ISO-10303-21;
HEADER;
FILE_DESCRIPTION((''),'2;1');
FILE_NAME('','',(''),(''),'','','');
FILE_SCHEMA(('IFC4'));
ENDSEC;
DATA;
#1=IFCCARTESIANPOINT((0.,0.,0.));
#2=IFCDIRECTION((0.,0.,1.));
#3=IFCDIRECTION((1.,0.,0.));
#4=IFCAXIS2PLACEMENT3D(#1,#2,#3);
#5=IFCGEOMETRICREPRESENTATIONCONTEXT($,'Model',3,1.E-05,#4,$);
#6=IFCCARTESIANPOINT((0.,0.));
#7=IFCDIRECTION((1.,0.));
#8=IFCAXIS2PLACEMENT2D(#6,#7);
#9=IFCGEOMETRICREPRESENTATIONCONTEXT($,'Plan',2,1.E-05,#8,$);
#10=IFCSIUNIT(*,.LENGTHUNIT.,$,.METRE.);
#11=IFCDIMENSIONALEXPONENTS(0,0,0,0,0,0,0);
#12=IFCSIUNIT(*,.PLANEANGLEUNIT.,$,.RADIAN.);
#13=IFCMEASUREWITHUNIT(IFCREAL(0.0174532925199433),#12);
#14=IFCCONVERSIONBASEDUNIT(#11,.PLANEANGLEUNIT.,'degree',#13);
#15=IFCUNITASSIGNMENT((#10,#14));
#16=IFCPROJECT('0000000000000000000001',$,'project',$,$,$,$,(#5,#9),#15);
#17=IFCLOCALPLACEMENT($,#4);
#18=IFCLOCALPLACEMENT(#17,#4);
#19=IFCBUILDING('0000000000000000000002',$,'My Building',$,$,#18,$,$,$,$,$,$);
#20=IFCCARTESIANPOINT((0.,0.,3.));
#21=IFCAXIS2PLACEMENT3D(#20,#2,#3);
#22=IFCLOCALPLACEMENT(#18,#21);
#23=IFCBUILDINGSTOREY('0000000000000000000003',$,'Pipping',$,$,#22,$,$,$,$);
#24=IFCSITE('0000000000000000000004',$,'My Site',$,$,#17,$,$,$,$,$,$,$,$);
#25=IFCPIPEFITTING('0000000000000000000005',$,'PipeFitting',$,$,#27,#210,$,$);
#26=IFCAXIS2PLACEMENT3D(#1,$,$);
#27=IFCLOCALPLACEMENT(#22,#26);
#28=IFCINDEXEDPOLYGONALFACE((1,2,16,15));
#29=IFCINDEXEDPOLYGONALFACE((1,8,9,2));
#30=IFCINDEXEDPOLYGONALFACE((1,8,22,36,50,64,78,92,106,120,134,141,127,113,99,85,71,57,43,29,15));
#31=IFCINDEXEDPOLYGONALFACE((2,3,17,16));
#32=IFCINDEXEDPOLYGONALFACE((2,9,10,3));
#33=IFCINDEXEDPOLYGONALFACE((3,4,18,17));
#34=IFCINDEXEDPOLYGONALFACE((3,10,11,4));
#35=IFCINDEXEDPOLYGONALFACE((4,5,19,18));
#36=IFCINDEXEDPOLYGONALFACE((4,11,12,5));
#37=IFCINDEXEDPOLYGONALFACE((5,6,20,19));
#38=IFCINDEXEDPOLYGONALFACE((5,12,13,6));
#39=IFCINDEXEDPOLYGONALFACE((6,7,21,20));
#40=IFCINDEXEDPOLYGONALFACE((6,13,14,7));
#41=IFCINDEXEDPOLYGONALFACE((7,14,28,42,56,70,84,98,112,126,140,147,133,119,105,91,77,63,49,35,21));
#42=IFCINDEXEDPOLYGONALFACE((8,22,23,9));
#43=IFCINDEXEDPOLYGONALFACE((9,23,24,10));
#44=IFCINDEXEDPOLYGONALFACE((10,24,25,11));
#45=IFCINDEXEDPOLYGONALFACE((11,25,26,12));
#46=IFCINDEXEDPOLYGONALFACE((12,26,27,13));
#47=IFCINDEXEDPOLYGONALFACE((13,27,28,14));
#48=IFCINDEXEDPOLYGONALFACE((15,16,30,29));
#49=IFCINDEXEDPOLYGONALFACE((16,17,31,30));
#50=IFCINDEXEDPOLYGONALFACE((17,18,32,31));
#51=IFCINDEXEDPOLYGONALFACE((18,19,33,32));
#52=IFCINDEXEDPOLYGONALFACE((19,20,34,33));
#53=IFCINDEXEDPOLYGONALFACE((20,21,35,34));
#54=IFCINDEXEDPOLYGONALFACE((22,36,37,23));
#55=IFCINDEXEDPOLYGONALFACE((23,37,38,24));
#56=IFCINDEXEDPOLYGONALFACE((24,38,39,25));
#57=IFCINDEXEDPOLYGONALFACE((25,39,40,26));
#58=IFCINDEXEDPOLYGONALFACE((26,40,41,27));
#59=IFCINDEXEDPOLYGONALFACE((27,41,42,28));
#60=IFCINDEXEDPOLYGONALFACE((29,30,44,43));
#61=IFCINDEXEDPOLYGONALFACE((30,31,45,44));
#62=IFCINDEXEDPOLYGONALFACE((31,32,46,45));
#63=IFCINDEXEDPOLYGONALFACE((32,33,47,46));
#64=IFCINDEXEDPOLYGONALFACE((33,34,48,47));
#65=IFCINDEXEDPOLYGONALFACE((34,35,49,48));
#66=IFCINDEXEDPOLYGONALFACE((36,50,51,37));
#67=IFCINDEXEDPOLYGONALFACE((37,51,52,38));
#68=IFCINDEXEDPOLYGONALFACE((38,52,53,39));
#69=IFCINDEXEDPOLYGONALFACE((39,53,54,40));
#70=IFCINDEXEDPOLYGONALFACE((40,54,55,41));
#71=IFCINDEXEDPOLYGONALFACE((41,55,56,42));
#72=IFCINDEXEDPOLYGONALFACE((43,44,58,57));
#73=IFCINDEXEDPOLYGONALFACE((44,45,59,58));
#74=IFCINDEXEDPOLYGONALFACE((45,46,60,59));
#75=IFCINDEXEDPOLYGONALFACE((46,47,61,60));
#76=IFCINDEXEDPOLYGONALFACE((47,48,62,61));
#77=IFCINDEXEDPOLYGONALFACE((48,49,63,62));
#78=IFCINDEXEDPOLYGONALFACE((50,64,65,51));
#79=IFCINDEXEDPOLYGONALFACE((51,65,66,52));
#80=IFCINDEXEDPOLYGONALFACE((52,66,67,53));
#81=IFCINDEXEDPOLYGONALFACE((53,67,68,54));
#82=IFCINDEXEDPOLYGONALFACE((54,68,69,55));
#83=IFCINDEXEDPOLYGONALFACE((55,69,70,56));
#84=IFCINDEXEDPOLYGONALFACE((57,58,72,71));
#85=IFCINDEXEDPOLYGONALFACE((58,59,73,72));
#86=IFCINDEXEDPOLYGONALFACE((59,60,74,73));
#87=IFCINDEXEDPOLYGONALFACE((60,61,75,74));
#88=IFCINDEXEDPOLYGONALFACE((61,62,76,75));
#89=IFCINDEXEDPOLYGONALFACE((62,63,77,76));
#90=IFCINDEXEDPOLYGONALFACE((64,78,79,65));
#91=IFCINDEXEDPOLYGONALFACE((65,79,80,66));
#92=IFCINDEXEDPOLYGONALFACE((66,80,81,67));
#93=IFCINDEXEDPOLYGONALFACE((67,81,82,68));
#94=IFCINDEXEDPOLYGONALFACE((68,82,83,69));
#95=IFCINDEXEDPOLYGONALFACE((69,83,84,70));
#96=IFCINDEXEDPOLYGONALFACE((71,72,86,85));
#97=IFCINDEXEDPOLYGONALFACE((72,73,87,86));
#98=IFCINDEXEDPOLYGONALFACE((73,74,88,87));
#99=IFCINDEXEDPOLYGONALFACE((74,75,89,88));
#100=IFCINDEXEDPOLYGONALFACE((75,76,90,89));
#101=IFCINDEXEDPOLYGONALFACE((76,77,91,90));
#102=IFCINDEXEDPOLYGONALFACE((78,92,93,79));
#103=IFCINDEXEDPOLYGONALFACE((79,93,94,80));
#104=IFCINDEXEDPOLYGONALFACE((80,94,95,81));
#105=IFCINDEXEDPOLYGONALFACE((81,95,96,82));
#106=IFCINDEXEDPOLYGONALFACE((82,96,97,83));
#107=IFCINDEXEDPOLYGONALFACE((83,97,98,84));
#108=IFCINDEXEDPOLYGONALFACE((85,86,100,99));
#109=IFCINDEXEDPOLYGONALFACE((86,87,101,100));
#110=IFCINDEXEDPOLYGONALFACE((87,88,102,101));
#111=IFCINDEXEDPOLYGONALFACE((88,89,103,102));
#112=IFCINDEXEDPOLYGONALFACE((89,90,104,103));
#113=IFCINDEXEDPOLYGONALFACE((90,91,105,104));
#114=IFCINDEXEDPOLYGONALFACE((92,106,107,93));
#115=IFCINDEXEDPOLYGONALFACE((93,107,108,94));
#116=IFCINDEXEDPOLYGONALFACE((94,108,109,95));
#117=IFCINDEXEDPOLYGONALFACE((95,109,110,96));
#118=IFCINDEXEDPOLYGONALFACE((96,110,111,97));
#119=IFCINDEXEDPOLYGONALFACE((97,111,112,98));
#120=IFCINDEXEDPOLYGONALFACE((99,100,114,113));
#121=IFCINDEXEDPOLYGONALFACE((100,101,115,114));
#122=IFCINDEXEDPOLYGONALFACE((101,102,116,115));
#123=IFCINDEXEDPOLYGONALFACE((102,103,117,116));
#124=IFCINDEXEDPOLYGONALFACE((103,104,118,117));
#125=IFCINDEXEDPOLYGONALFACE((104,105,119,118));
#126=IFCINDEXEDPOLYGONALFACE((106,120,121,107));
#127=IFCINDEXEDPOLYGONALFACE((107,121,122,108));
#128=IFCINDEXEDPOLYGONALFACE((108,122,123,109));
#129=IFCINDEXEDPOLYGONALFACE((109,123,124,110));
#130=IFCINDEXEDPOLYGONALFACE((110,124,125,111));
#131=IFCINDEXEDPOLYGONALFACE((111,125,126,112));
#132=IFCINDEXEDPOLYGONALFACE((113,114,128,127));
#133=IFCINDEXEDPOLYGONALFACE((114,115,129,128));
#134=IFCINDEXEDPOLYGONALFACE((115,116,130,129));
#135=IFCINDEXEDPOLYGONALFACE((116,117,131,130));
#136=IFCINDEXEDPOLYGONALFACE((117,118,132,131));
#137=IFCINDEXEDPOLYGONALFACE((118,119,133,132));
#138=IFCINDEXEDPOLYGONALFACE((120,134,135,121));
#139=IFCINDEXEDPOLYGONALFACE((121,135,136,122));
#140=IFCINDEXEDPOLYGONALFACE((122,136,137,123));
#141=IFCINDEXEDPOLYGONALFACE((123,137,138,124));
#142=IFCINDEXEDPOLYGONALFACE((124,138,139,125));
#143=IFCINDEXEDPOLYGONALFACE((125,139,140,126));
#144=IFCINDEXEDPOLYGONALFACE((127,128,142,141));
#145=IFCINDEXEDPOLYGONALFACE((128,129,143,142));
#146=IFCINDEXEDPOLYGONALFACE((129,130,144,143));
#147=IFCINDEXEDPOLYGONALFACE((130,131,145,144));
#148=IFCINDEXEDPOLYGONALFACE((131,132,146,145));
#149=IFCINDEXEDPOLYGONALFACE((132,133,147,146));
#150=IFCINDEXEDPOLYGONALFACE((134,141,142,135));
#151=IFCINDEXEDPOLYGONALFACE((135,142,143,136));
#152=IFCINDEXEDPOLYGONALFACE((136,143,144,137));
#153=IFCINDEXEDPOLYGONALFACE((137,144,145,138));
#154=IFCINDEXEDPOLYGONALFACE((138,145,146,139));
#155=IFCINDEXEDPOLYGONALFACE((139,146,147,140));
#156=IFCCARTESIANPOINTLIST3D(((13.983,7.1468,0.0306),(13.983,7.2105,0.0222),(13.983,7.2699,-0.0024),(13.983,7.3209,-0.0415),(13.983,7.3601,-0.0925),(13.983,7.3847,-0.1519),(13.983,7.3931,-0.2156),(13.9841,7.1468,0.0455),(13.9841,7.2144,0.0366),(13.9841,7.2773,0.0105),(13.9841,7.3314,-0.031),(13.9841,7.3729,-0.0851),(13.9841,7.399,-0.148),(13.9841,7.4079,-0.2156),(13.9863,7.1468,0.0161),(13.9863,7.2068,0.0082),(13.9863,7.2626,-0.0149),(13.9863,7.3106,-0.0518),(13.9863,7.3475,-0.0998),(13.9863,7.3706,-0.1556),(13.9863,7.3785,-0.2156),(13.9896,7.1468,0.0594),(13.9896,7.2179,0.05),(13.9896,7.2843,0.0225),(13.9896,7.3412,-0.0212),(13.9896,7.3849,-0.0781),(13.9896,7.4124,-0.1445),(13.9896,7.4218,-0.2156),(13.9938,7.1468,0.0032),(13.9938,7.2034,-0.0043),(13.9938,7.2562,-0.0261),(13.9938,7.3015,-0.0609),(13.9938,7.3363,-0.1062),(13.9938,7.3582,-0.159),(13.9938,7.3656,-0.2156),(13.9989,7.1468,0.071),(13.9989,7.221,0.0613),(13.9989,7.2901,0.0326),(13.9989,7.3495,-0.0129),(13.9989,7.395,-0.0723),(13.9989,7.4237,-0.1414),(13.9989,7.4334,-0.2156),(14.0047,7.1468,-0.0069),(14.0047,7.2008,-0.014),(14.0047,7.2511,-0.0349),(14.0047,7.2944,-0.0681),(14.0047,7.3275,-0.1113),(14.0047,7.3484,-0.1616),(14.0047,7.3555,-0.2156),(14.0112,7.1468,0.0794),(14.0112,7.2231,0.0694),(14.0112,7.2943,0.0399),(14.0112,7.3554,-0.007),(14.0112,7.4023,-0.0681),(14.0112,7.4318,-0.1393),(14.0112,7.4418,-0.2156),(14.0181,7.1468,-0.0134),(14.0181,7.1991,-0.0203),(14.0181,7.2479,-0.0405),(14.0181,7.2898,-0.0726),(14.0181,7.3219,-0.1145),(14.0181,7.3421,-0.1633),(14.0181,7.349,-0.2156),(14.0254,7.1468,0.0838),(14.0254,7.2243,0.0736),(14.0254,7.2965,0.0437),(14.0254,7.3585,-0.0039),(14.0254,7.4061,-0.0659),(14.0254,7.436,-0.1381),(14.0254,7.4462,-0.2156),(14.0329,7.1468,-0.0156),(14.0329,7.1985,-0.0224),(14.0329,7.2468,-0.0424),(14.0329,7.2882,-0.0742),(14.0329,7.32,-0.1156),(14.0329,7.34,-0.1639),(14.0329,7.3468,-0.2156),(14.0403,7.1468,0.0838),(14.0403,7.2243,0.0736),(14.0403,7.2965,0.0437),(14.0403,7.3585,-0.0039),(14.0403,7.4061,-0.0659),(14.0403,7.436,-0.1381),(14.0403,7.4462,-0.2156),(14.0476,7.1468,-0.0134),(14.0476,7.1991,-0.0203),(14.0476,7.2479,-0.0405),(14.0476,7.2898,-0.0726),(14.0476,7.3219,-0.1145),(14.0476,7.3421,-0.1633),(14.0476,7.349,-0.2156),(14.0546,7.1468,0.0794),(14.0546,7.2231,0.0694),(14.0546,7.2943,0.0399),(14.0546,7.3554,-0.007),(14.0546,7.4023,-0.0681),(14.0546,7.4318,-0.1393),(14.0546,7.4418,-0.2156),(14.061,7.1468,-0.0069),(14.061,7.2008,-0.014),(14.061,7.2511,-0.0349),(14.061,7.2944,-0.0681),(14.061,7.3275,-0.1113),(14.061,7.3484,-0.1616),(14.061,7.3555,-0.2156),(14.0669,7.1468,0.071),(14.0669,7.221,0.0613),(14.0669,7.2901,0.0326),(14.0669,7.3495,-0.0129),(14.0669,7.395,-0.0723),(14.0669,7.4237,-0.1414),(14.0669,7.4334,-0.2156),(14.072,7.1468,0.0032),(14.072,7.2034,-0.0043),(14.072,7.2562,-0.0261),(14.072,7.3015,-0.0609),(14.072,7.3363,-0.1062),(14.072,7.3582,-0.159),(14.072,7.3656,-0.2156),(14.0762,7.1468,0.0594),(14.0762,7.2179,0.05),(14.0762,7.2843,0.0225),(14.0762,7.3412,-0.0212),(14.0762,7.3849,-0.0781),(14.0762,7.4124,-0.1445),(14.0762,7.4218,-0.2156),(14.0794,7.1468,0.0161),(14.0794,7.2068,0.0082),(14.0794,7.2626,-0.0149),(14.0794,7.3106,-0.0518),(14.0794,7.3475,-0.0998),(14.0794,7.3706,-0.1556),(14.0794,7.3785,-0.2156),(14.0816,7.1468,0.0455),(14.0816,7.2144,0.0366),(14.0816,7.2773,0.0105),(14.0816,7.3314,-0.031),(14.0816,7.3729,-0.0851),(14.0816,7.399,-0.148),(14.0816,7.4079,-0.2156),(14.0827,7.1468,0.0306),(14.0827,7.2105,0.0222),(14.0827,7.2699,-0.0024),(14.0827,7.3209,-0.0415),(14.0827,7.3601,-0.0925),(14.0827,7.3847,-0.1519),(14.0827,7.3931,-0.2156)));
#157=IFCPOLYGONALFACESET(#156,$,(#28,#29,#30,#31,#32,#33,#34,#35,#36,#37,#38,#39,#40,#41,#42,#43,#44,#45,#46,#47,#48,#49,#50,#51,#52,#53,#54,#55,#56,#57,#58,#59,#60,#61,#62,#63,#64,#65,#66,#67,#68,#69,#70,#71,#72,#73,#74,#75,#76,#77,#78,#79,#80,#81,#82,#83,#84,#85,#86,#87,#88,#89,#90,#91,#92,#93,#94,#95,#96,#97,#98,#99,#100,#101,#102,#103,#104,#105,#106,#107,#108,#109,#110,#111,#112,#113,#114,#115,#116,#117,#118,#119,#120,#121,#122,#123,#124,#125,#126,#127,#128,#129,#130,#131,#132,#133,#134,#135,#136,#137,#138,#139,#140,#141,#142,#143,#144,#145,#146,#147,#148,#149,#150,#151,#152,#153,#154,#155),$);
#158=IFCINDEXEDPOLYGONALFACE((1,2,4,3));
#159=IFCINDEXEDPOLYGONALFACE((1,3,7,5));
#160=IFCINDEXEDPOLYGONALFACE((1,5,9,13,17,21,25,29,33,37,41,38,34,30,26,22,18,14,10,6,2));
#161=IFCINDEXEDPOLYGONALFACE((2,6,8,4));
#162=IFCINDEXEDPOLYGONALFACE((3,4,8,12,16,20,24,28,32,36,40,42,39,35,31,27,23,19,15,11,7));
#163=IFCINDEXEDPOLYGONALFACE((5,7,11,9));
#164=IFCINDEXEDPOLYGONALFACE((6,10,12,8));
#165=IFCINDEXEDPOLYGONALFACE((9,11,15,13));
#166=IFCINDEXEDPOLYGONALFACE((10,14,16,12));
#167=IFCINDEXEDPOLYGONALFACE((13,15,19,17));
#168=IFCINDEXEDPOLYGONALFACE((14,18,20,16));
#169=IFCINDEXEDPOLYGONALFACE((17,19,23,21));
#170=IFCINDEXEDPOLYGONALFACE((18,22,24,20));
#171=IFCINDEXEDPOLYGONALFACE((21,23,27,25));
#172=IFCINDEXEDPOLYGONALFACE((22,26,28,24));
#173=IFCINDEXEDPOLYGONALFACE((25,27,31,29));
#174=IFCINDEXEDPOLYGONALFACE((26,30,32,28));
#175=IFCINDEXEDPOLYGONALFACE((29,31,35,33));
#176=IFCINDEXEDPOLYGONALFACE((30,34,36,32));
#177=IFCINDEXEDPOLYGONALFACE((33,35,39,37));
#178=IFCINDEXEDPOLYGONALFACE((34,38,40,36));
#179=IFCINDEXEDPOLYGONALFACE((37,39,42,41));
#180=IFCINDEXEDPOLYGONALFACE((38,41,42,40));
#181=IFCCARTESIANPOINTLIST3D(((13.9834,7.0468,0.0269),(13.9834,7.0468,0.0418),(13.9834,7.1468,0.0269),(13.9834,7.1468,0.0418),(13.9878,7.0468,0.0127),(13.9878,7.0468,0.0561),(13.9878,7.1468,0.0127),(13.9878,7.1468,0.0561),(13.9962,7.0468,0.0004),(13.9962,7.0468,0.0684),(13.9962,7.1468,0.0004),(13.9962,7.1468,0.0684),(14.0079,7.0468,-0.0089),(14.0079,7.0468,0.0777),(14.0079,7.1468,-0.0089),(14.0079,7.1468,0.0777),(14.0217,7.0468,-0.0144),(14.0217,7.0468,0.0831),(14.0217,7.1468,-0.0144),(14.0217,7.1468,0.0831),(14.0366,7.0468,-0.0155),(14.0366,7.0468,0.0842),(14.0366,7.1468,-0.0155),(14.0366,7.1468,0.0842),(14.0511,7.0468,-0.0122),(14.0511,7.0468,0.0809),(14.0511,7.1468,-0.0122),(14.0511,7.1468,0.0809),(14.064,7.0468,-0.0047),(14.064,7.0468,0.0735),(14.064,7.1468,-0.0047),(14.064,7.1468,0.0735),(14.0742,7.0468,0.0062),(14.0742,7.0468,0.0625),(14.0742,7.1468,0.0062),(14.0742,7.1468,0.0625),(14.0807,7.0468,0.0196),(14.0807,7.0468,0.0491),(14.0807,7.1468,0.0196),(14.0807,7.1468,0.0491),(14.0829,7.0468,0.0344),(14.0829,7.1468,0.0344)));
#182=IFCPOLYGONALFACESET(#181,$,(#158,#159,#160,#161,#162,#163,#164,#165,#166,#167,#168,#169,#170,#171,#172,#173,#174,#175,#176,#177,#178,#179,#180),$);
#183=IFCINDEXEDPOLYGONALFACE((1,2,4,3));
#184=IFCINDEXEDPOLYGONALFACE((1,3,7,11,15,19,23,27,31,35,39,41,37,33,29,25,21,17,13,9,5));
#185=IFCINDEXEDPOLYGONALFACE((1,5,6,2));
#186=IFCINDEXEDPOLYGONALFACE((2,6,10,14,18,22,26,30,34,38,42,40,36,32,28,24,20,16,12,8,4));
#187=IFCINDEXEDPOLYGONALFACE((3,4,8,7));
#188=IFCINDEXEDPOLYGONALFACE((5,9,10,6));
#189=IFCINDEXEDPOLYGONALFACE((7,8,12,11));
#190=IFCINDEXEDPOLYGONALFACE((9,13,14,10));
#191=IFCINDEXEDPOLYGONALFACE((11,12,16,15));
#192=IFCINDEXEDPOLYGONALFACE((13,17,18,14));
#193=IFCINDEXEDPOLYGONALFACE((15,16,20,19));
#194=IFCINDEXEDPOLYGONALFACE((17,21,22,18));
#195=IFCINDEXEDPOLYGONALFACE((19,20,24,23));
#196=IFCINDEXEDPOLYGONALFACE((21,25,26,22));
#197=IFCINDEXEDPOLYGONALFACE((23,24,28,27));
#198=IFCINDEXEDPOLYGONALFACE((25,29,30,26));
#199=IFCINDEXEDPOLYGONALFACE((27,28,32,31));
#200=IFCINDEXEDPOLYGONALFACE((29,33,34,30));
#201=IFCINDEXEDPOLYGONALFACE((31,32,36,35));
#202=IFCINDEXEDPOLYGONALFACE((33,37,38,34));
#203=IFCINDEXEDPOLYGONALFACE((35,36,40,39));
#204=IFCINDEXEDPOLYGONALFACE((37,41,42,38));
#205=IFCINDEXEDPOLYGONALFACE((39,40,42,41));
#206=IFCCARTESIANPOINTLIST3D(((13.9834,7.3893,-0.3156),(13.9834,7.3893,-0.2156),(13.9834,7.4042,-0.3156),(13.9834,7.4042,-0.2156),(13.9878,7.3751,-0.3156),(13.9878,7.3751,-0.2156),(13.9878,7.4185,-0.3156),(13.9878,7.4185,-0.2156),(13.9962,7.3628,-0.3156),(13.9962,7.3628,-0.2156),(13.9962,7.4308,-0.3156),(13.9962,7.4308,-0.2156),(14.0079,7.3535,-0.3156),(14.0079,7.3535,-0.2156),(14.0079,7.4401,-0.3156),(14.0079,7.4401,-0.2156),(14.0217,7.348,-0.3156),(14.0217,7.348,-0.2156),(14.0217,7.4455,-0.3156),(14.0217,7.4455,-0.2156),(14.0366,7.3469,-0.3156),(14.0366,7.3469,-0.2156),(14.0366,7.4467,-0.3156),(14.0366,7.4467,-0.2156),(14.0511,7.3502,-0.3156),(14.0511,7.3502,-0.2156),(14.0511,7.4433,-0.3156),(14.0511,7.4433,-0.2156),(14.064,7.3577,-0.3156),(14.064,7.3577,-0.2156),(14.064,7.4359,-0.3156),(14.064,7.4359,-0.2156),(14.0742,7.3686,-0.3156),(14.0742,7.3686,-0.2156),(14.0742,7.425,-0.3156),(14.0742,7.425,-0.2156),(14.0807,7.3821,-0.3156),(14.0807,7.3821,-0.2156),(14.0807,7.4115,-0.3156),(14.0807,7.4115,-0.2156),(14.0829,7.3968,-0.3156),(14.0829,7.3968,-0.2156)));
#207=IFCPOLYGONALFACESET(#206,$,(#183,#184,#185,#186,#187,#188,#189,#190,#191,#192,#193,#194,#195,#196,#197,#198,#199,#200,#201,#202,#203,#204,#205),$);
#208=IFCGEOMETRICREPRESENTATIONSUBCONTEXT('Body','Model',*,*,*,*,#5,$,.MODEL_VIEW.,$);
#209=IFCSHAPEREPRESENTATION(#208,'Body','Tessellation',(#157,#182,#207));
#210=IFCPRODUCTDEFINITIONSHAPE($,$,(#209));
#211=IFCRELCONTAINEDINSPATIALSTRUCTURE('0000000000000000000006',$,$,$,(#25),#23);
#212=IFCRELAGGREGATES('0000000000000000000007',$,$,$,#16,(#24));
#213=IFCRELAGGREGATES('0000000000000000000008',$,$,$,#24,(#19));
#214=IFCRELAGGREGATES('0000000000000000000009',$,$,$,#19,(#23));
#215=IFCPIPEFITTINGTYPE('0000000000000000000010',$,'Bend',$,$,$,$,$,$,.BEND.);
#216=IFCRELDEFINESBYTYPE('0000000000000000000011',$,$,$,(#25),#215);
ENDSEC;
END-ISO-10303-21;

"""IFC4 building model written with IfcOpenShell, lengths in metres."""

from ifc_helpers import new_model, entity, si_unit, converted_unit, frame, origin_with_axes, origin_2d_with_axis, place, context, subcontext, project, spatial, circle, extrude, source, transform, mapped, type_object, type_shapes, element, save


model = new_model("IFC4")

# Units and contexts
model_context = context("Model", 3, precision=1e-05, world=origin_with_axes())
plan_context = context("Plan", 2, precision=1e-05, world=origin_2d_with_axis())
body_context = subcontext(model_context, "Body", "Model", "MODEL_VIEW")
ifc_project = project(units=[si_unit("LENGTHUNIT", "METRE"), converted_unit("PLANEANGLEUNIT", "degree", entity("IfcReal", 0.0174532925199433), si_unit("PLANEANGLEUNIT", "RADIAN"), dimensions=[0, 0, 0, 0, 0, 0, 0])], contexts=[model_context, plan_context])

# Site, building, storey
site_placement = place(None, origin_with_axes())
site = spatial("IfcSite", under=ifc_project, at=site_placement, Name="My Site")
building_placement = place(site_placement, origin_with_axes())
building = spatial("IfcBuilding", under=site, at=building_placement, Name="My Building")
storey_placement = place(building_placement, frame((0.0, 0.0, 3.0), z_axis=(0.0, 0.0, 1.0), x_axis=(1.0, 0.0, 0.0)))
storey = spatial("IfcBuildingStorey", under=building, at=storey_placement, Name="Pipping")

# Pipe fitting
pipe_fitting_type_1 = type_object("IfcPipeFittingType", Name="Bend", PredefinedType="BEND")
shared_shape_1 = source(origin_with_axes(), body_context, "Body", "SolidModel", [
    entity("IfcSweptDiskSolid", entity("IfcIndexedPolyCurve", entity("IfcCartesianPointList3D", [[0.0, 0.0, 0.1], [0.0, 0.0732, 0.2768], [0.0, 0.25, 0.35]]), [entity("IfcArcIndex", [1, 2, 3])]), 0.05),
    extrude(circle(Radius=0.05), origin_with_axes(), (0.0, 0.0, 1.0), 0.1),
    extrude(circle(Radius=0.05), frame((0.0, 0.25, 0.35), z_axis=(0.0, 1.0, -0.000073), x_axis=(1.0, 0.0, 0.0)), (0.0, 0.0, 1.0), 0.1),
])
type_shapes(pipe_fitting_type_1, [shared_shape_1])
for number, where, z_axis, x_axis, name in (
    (1, (14.0329, 7.0468, 0.0344), (0.0, 1.0, 0.000073), (1.0, 0.0, 0.0), "PipeFitting"),
):
    element("IfcPipeFitting", number, at=place(storey_placement, frame(where, z_axis=z_axis, x_axis=x_axis)), inside=storey, type_object=pipe_fitting_type_1, Name=name, context=body_context, shape_type="MappedRepresentation", body=[
        mapped(shared_shape_1, transform((0.0, 0.0, 0.0), x_axis=(1.0, 0.0, 0.0), y_axis=(0.0, 1.0, 0.0), z_axis=(0.0, 0.0, 1.0), scale=1.0)),
    ])

save(model, "model.ifc")
